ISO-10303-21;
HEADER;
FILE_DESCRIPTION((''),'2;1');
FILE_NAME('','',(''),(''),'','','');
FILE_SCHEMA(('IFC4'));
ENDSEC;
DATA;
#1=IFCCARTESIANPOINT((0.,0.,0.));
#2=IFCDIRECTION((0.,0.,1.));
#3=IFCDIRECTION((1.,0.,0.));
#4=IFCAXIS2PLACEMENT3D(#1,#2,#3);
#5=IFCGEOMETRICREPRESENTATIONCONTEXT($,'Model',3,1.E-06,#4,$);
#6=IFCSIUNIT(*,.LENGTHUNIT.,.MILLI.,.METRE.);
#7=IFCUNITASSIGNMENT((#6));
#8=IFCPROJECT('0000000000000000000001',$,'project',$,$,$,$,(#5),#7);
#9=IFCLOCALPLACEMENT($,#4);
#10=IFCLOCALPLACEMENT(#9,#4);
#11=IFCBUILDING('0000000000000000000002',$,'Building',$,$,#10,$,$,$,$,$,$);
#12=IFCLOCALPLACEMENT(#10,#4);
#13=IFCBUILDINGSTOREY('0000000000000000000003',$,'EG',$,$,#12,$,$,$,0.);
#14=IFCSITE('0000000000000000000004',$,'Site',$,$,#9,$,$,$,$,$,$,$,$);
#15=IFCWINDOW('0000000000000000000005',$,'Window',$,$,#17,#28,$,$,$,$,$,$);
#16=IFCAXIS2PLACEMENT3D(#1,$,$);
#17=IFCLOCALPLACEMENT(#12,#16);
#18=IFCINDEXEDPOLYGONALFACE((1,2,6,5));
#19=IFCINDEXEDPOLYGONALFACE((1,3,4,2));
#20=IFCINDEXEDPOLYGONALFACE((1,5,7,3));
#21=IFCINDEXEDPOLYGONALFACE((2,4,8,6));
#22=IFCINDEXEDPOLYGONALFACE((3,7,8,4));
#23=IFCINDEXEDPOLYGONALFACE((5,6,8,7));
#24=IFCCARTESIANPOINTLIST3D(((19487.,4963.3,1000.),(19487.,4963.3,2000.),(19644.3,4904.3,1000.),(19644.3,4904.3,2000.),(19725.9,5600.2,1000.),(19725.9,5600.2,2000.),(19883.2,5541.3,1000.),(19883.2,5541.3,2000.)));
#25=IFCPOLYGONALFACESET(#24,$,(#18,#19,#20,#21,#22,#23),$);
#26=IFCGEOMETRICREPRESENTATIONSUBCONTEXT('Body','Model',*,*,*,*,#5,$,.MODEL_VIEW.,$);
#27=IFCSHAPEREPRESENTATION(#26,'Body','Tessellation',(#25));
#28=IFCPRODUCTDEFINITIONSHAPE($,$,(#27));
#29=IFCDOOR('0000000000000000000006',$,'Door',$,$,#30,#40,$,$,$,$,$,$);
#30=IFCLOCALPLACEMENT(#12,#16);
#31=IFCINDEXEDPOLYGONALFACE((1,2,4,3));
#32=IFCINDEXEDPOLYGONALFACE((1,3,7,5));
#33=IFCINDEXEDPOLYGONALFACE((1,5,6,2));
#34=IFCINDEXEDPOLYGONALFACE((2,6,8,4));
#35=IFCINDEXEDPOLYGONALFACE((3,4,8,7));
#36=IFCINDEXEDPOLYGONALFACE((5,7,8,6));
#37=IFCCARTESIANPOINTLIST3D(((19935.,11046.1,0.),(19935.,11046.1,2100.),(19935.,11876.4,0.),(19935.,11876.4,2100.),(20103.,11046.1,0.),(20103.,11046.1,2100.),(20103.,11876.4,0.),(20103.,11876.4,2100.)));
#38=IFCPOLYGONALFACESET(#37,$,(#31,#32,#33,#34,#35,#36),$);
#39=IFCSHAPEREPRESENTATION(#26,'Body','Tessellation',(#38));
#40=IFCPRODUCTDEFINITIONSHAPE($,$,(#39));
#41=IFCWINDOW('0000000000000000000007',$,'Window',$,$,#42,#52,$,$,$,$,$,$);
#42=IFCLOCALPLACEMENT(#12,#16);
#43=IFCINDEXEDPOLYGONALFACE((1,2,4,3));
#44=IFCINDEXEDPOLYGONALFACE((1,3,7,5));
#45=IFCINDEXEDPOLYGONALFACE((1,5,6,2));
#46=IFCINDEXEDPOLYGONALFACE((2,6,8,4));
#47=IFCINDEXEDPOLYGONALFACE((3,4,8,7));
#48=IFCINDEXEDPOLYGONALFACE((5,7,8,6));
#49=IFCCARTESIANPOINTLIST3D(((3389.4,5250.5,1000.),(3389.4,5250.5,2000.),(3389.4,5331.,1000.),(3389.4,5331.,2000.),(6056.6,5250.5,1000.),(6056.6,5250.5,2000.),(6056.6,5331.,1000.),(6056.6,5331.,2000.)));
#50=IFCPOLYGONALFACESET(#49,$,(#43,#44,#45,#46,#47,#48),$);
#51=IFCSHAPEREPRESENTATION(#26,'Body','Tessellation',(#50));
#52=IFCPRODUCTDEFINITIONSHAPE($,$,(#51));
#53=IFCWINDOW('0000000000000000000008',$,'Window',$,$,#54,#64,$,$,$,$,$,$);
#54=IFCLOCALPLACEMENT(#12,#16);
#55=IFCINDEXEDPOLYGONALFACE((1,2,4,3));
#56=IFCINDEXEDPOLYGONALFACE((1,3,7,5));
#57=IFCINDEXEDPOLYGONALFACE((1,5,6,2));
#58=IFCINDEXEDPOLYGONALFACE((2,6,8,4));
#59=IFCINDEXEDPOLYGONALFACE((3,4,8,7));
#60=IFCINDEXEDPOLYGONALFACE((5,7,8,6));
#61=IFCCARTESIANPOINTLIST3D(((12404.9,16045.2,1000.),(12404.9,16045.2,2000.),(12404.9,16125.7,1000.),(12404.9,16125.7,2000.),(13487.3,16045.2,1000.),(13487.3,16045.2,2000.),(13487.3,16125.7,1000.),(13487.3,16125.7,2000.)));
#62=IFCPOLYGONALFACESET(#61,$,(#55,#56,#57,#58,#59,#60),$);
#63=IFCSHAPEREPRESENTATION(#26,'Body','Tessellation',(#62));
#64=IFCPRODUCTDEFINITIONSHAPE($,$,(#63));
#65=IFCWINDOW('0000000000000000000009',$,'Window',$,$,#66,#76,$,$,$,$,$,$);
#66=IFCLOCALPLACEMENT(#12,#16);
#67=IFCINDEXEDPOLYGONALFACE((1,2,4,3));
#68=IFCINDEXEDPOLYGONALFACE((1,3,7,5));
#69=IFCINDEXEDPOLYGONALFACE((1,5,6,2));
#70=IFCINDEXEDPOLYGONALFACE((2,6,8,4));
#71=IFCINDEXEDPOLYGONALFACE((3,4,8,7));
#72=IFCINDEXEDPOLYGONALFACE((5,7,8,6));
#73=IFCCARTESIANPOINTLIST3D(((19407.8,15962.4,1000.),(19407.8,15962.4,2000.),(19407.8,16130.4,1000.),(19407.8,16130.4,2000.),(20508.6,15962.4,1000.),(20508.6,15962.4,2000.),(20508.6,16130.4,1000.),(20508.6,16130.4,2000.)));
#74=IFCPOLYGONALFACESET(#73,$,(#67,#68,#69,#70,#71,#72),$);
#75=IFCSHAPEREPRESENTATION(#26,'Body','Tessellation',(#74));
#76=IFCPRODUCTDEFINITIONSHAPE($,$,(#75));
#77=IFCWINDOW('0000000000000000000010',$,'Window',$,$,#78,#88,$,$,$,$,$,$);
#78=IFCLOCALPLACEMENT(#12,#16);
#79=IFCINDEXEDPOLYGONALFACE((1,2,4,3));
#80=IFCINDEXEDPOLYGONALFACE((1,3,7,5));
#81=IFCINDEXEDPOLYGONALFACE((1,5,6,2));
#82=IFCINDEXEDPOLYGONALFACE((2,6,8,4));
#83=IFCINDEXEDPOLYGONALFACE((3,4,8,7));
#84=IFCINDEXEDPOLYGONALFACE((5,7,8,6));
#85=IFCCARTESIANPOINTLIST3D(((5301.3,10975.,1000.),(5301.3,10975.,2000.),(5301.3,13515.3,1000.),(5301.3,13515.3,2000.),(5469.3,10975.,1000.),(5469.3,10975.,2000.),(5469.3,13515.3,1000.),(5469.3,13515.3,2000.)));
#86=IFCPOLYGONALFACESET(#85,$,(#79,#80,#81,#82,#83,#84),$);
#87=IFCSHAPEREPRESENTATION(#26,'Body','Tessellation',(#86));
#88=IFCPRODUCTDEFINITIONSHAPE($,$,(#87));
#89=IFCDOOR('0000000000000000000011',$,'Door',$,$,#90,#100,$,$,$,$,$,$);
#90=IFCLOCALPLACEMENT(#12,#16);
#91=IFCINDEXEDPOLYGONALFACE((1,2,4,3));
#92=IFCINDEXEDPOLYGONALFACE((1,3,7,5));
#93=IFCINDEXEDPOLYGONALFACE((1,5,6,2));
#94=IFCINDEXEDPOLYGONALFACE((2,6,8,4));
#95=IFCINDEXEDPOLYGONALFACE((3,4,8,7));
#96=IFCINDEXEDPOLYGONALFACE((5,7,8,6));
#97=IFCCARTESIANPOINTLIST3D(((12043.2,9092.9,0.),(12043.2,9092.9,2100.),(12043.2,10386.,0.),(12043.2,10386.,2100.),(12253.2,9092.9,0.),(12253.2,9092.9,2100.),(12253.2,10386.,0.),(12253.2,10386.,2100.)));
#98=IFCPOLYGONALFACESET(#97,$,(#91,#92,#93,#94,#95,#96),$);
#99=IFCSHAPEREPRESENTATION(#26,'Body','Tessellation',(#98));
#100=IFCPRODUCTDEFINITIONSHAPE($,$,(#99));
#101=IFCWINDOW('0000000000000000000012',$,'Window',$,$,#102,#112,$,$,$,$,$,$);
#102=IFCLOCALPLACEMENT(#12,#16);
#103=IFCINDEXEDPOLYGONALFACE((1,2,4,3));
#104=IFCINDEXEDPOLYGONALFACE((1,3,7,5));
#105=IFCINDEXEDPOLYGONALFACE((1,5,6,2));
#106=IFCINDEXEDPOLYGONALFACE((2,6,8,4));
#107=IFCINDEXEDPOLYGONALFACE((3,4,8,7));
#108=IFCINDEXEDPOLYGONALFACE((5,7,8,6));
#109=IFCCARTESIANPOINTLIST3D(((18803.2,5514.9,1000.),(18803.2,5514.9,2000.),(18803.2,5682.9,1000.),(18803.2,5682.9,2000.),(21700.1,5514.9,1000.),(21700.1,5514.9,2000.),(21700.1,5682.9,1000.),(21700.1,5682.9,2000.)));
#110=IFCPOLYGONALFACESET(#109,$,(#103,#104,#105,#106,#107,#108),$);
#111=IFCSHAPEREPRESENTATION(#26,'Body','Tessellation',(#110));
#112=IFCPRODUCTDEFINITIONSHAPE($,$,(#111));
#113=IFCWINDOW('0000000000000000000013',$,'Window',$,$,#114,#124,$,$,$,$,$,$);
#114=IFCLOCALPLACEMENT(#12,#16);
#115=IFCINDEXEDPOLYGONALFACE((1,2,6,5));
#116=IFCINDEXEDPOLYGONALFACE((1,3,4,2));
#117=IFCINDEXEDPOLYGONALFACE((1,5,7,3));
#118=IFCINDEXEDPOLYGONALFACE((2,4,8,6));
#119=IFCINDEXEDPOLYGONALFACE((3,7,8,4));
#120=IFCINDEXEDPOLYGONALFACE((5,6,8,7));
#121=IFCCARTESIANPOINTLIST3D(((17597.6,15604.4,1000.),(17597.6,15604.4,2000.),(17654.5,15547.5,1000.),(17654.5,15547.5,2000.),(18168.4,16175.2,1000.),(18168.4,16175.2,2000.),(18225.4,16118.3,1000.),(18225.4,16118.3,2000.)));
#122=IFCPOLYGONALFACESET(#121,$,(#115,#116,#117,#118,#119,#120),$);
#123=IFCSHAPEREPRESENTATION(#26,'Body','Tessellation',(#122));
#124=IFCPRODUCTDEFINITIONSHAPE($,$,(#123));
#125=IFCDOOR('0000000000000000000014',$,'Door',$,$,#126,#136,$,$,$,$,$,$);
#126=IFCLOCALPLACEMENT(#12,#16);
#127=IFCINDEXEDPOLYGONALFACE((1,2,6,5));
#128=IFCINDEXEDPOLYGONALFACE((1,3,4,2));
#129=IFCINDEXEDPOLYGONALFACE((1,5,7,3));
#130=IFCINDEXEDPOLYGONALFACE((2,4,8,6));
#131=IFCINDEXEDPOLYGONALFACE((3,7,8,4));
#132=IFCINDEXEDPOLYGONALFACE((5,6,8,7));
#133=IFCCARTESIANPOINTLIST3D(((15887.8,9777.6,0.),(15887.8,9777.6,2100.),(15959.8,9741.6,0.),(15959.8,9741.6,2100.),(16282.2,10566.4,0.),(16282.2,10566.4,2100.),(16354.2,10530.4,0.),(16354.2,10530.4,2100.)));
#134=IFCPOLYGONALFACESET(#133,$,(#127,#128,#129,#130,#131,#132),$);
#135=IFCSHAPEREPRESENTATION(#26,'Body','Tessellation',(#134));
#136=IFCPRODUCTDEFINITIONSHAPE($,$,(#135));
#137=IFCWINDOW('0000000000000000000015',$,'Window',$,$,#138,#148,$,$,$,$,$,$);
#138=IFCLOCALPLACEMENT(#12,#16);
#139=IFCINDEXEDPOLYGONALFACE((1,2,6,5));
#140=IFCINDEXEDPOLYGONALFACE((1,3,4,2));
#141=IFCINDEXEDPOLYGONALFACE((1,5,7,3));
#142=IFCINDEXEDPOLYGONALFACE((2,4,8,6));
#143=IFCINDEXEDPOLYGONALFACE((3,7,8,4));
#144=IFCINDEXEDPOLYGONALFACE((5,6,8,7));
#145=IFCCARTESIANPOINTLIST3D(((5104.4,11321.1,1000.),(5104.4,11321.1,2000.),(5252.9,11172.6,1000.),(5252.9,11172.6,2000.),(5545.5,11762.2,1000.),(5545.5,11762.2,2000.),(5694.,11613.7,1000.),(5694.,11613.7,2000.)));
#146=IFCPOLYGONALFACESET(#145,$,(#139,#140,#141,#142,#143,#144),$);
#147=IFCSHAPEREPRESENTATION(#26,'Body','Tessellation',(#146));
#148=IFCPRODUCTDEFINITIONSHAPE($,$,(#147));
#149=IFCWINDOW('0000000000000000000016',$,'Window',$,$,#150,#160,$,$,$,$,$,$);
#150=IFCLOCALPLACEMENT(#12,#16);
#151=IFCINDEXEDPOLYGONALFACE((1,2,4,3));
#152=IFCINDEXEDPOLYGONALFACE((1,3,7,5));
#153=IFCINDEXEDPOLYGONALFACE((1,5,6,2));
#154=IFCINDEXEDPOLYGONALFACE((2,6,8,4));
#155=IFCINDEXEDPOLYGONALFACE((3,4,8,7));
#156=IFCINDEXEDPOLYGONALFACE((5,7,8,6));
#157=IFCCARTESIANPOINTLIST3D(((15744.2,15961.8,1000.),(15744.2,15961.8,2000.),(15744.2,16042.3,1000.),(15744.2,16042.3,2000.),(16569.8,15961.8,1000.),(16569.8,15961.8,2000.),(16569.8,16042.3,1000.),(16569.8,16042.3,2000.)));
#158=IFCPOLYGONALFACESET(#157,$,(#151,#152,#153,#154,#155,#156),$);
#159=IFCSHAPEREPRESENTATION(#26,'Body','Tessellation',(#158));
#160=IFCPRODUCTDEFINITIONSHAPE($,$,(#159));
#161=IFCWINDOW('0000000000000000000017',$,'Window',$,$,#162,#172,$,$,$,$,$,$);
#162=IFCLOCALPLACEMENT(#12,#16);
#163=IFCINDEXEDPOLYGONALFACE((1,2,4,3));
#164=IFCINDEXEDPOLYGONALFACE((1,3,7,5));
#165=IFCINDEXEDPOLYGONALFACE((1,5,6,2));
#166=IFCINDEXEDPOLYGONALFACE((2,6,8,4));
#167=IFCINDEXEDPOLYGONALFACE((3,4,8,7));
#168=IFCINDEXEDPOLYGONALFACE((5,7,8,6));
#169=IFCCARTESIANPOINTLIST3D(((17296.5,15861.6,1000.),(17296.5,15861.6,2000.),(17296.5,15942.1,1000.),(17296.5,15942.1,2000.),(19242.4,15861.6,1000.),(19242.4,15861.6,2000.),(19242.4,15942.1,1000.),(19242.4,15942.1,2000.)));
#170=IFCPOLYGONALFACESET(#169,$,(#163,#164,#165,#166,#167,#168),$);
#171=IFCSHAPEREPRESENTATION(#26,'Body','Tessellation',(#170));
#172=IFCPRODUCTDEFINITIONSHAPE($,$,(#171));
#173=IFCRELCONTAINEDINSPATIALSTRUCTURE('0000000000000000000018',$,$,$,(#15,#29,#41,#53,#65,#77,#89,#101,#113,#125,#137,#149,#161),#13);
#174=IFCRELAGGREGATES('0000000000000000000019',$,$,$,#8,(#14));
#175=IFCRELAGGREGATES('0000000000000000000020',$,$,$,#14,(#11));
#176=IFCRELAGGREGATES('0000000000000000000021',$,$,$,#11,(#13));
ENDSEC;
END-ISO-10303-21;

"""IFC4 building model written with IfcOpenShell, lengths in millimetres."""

from ifc_helpers import new_model, si_unit, frame, origin_with_axes, place, context, subcontext, project, spatial, rectangle, extrude, element, save


model = new_model("IFC4")

# Units and contexts
model_context = context("Model", 3, precision=1e-06, world=origin_with_axes())
body_context = subcontext(model_context, "Body", "Model", "MODEL_VIEW")
ifc_project = project(units=[si_unit("LENGTHUNIT", "METRE", prefix="MILLI")], contexts=[model_context])

# Site, building, storey
site_placement = place(None, origin_with_axes())
site = spatial("IfcSite", under=ifc_project, at=site_placement, Name="Site")
building_placement = place(site_placement, origin_with_axes())
building = spatial("IfcBuilding", under=site, at=building_placement, Name="Building")
storey_placement = place(building_placement, origin_with_axes())
storey = spatial("IfcBuildingStorey", under=building, at=storey_placement, Name="EG", Elevation=0.0)

# Window
window_1_placement = place(storey_placement, origin_with_axes())
element("IfcWindow", 1, at=window_1_placement, inside=storey, Name="Window", context=body_context, shape_type="SweptSolid", body=[
    extrude(rectangle(XDim=680.2, YDim=168.0), frame((19685.1, 5252.3, 1000.0), z_axis=(0.0, 0.0, 1.0), x_axis=(0.351123, 0.936329, 0.0)), (0.0, 0.0, 1.0), 1000.0),
])

# Door
door_1_placement = place(storey_placement, origin_with_axes())
element("IfcDoor", 2, at=door_1_placement, inside=storey, Name="Door", context=body_context, shape_type="SweptSolid", body=[
    extrude(rectangle(XDim=830.3, YDim=168.0), frame((20019.0, 11461.3, 0.0), z_axis=(0.0, 0.0, 1.0), x_axis=(0.0, -1.0, 0.0)), (0.0, 0.0, 1.0), 2100.0),
])

# Windows
window_2_placement = place(storey_placement, origin_with_axes())
element("IfcWindow", 3, at=window_2_placement, inside=storey, Name="Window", context=body_context, shape_type="SweptSolid", body=[
    extrude(rectangle(XDim=2667.3, YDim=80.5), frame((4723.0, 5290.7, 1000.0), z_axis=(0.0, 0.0, 1.0), x_axis=(1.0, 0.0, 0.0)), (0.0, 0.0, 1.0), 1000.0),
])
window_3_placement = place(storey_placement, origin_with_axes())
element("IfcWindow", 4, at=window_3_placement, inside=storey, Name="Window", context=body_context, shape_type="SweptSolid", body=[
    extrude(rectangle(XDim=1082.5, YDim=80.5), frame((12946.1, 16085.4, 1000.0), z_axis=(0.0, 0.0, 1.0), x_axis=(1.0, 0.0, 0.0)), (0.0, 0.0, 1.0), 1000.0),
])
window_4_placement = place(storey_placement, origin_with_axes())
element("IfcWindow", 5, at=window_4_placement, inside=storey, Name="Window", context=body_context, shape_type="SweptSolid", body=[
    extrude(rectangle(XDim=1100.8, YDim=168.0), frame((19958.2, 16046.4, 1000.0), z_axis=(0.0, 0.0, 1.0), x_axis=(1.0, 0.0, 0.0)), (0.0, 0.0, 1.0), 1000.0),
])
window_5_placement = place(storey_placement, origin_with_axes())
element("IfcWindow", 6, at=window_5_placement, inside=storey, Name="Window", context=body_context, shape_type="SweptSolid", body=[
    extrude(rectangle(XDim=2540.3, YDim=168.0), frame((5385.3, 12245.1, 1000.0), z_axis=(0.0, 0.0, 1.0), x_axis=(0.0, 1.0, 0.0)), (0.0, 0.0, 1.0), 1000.0),
])

# Door
door_2_placement = place(storey_placement, origin_with_axes())
element("IfcDoor", 7, at=door_2_placement, inside=storey, Name="Door", context=body_context, shape_type="SweptSolid", body=[
    extrude(rectangle(XDim=1293.1, YDim=210.0), frame((12148.2, 9739.4, 0.0), z_axis=(0.0, 0.0, 1.0), x_axis=(0.0, 1.0, 0.0)), (0.0, 0.0, 1.0), 2100.0),
])

# Windows
window_6_placement = place(storey_placement, origin_with_axes())
element("IfcWindow", 8, at=window_6_placement, inside=storey, Name="Window", context=body_context, shape_type="SweptSolid", body=[
    extrude(rectangle(XDim=2896.9, YDim=168.0), frame((20251.7, 5598.9, 1000.0), z_axis=(0.0, 0.0, 1.0), x_axis=(1.0, 0.0, 0.0)), (0.0, 0.0, 1.0), 1000.0),
])
window_7_placement = place(storey_placement, origin_with_axes())
element("IfcWindow", 9, at=window_7_placement, inside=storey, Name="Window", context=body_context, shape_type="SweptSolid", body=[
    extrude(rectangle(XDim=807.3, YDim=80.5), frame((17911.5, 15861.3, 1000.0), z_axis=(0.0, 0.0, 1.0), x_axis=(-0.707107, -0.707107, 0.0)), (0.0, 0.0, 1.0), 1000.0),
])

# Door
door_3_placement = place(storey_placement, origin_with_axes())
element("IfcDoor", 10, at=door_3_placement, inside=storey, Name="Door", context=body_context, shape_type="SweptSolid", body=[
    extrude(rectangle(XDim=881.9, YDim=80.5), frame((16121.0, 10154.0, 0.0), z_axis=(0.0, 0.0, 1.0), x_axis=(0.447214, 0.894427, 0.0)), (0.0, 0.0, 1.0), 2100.0),
])

# Windows
window_8_placement = place(storey_placement, origin_with_axes())
element("IfcWindow", 11, at=window_8_placement, inside=storey, Name="Window", context=body_context, shape_type="SweptSolid", body=[
    extrude(rectangle(XDim=623.8, YDim=210.0), frame((5399.2, 11467.4, 1000.0), z_axis=(0.0, 0.0, 1.0), x_axis=(-0.707107, -0.707107, 0.0)), (0.0, 0.0, 1.0), 1000.0),
])
window_9_placement = place(storey_placement, origin_with_axes())
element("IfcWindow", 12, at=window_9_placement, inside=storey, Name="Window", context=body_context, shape_type="SweptSolid", body=[
    extrude(rectangle(XDim=825.6, YDim=80.5), frame((16157.0, 16002.1, 1000.0), z_axis=(0.0, 0.0, 1.0), x_axis=(1.0, 0.0, 0.0)), (0.0, 0.0, 1.0), 1000.0),
])
window_10_placement = place(storey_placement, origin_with_axes())
element("IfcWindow", 13, at=window_10_placement, inside=storey, Name="Window", context=body_context, shape_type="SweptSolid", body=[
    extrude(rectangle(XDim=1946.0, YDim=80.5), frame((18269.4, 15901.8, 1000.0), z_axis=(0.0, 0.0, 1.0), x_axis=(1.0, 0.0, 0.0)), (0.0, 0.0, 1.0), 1000.0),
])

save(model, "model.ifc")
